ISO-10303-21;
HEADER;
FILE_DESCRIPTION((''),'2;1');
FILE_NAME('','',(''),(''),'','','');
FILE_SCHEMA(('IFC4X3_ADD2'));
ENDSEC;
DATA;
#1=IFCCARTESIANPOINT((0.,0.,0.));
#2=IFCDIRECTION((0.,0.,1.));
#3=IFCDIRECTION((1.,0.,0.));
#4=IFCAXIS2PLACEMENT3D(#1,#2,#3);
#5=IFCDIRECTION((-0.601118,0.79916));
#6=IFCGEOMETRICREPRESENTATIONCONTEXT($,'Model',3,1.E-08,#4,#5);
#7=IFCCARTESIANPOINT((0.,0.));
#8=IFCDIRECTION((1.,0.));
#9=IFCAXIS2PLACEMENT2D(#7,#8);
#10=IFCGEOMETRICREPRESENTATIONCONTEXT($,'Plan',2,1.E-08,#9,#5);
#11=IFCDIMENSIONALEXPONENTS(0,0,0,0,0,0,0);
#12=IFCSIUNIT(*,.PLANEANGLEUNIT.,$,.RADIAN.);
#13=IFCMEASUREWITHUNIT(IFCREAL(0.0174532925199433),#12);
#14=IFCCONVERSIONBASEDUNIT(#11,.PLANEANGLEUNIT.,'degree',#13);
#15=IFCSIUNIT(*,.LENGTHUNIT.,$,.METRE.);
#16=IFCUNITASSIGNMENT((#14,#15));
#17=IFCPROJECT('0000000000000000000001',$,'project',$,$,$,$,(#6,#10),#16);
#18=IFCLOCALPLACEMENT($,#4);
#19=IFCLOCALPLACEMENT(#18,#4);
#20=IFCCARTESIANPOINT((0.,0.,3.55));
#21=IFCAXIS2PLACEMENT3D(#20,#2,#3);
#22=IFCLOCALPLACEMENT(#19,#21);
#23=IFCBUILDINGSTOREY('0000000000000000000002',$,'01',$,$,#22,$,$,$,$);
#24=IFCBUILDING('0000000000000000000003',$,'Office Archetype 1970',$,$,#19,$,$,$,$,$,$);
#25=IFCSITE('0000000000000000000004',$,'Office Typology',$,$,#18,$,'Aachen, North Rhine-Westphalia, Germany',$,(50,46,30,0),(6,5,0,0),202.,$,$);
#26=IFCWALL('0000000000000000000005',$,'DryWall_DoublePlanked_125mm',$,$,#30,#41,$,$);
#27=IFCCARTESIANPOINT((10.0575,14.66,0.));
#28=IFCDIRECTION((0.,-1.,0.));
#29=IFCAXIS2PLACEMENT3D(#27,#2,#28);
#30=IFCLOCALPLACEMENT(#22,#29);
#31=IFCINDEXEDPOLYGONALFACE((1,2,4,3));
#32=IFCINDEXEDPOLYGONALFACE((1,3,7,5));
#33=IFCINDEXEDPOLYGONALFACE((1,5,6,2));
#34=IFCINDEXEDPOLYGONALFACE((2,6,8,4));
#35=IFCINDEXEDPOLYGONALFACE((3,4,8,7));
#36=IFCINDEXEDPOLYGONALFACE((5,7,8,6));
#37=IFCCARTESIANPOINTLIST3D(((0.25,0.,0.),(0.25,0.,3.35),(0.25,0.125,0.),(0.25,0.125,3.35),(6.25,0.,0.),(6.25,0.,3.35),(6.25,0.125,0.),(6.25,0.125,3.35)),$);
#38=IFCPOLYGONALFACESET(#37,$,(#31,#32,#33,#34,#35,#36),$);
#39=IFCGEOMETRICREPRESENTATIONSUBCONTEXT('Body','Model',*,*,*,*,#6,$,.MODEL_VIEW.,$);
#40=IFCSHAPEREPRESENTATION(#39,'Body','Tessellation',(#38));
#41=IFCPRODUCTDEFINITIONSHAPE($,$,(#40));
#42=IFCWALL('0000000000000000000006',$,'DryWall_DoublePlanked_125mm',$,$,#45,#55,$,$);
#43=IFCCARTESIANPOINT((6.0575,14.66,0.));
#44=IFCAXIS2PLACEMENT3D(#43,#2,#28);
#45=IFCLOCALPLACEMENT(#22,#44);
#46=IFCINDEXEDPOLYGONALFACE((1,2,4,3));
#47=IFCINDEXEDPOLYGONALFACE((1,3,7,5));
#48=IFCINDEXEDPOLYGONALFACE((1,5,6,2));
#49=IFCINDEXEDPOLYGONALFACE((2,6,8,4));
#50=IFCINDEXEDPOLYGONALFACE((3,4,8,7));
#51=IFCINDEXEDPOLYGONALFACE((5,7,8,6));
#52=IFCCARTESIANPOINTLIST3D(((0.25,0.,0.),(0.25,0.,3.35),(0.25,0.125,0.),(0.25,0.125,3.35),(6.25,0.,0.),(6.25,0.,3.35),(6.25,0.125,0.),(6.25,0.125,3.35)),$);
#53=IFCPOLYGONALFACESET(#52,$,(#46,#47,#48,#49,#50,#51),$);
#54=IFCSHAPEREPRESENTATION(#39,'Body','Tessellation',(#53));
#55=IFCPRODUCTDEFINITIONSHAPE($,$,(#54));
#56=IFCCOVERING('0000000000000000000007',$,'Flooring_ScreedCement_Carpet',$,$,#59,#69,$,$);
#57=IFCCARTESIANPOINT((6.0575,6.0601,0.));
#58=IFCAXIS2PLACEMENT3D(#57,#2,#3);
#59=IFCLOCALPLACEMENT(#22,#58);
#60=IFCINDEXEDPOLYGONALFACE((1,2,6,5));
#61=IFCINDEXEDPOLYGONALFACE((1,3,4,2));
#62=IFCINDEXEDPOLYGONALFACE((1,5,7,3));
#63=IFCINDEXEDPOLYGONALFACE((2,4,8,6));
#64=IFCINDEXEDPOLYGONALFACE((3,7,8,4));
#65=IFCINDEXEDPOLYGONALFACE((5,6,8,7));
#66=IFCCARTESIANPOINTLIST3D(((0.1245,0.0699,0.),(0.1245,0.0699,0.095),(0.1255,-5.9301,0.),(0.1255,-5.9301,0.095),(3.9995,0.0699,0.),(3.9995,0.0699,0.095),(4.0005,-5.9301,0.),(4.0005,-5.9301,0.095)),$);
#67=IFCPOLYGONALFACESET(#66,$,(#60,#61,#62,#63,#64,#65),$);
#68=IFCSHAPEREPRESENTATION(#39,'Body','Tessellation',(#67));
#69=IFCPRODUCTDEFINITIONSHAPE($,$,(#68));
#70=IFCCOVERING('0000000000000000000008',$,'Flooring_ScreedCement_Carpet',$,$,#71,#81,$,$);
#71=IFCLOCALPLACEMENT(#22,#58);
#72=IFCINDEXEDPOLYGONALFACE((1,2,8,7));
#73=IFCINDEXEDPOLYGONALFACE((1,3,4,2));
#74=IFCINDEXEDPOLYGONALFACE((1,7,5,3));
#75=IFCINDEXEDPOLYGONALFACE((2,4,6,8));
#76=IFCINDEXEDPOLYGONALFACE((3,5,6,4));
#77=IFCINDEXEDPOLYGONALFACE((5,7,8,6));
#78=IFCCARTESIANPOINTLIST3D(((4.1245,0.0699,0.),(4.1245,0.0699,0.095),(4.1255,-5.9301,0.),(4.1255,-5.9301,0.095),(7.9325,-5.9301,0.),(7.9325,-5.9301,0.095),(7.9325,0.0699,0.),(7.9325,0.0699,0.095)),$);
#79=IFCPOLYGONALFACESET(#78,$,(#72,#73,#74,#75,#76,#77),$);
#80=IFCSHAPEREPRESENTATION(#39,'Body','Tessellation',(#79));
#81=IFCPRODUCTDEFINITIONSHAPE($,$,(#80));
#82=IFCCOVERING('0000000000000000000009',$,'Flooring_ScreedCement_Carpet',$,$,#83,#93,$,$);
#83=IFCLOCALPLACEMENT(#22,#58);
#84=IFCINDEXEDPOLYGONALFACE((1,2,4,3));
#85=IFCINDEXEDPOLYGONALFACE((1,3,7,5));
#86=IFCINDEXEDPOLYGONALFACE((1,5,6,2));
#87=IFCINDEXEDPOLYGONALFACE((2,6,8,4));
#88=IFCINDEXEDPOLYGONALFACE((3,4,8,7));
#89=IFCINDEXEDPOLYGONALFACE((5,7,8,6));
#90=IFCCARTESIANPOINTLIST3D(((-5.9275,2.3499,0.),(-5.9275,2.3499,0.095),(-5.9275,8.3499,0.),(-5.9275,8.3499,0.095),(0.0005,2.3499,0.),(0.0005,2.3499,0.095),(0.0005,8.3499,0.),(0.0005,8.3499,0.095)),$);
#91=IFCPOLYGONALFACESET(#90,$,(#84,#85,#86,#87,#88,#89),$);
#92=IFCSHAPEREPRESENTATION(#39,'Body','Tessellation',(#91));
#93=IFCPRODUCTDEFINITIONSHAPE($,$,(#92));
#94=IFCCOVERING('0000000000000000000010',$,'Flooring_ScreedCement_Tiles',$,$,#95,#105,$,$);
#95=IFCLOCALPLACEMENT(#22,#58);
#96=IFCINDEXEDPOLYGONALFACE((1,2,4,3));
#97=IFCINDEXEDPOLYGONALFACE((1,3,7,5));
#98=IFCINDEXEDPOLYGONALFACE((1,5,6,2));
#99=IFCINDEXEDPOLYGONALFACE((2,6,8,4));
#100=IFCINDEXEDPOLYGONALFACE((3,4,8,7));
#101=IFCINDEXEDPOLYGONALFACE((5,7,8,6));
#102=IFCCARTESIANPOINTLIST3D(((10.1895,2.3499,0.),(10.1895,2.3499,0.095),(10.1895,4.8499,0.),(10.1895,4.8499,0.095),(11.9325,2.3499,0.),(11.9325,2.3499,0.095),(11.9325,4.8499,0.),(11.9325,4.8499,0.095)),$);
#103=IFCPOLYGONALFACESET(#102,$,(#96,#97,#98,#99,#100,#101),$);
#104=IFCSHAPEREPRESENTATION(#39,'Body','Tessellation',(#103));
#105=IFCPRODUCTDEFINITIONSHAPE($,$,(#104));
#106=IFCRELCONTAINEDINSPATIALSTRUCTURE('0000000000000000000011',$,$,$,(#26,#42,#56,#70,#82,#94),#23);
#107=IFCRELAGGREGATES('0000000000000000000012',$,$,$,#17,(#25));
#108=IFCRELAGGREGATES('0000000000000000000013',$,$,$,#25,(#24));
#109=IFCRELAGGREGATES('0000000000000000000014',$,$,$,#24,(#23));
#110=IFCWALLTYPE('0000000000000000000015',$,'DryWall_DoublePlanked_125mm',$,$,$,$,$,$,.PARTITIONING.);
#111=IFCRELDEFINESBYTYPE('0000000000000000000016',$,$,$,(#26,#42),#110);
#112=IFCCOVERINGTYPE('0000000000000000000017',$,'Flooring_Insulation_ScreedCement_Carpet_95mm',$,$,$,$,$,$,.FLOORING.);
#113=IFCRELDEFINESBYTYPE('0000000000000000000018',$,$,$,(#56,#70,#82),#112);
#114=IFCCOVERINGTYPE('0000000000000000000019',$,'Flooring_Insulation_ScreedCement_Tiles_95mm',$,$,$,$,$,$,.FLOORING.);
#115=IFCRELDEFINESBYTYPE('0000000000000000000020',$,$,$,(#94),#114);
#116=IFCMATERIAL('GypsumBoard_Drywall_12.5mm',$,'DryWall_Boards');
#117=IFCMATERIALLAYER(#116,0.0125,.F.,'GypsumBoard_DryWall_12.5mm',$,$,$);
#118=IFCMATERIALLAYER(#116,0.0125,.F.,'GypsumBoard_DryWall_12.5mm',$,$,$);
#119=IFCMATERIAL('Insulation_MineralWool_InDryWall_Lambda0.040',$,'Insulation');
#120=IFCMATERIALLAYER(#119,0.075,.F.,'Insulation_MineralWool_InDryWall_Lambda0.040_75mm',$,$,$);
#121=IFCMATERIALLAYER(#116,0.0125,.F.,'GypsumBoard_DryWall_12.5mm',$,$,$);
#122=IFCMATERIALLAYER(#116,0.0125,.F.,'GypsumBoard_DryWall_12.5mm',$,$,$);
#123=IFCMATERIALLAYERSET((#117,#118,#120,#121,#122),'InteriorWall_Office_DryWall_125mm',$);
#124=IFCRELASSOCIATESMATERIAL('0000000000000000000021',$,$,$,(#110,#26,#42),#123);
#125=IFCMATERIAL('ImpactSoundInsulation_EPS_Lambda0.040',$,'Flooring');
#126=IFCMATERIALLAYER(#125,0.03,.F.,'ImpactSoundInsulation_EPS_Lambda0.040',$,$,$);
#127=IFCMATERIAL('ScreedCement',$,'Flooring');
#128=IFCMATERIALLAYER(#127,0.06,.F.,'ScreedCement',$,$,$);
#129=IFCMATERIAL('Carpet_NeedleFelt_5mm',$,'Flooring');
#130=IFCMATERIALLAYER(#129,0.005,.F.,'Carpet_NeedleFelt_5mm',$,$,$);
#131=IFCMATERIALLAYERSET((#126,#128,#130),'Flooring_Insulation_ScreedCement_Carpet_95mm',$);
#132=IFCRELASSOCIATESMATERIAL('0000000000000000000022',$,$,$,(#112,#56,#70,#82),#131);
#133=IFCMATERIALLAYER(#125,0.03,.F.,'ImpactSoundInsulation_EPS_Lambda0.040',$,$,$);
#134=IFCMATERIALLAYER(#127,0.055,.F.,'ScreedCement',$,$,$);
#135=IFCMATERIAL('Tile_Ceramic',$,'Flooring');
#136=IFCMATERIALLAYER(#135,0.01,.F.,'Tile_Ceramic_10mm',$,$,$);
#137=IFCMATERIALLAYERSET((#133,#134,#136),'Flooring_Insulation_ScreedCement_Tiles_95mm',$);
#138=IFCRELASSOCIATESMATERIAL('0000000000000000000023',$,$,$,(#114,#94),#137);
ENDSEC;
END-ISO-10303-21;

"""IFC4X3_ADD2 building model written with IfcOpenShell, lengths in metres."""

from ifc_helpers import new_model, entity, si_unit, converted_unit, direction, frame, origin_with_axes, origin_2d_with_axis, place, context, subcontext, project, spatial, line, indexed_curve, outline, extrude, material, layer, layer_set, layer_usage, type_object, element, save


model = new_model("IFC4X3_ADD2")

# Units and contexts
model_context = context("Model", 3, precision=1e-08, world=origin_with_axes(), true_north=direction((-0.601118, 0.79916)))
plan_context = context("Plan", 2, precision=1e-08, world=origin_2d_with_axis(), true_north=direction((-0.601118, 0.79916)))
body_context = subcontext(model_context, "Body", "Model", "MODEL_VIEW")
ifc_project = project(units=[converted_unit("PLANEANGLEUNIT", "degree", entity("IfcReal", 0.0174532925199433), si_unit("PLANEANGLEUNIT", "RADIAN"), dimensions=[0, 0, 0, 0, 0, 0, 0]), si_unit("LENGTHUNIT", "METRE")], contexts=[model_context, plan_context])

# Site, building, storey
site_placement = place(None, origin_with_axes())
site = spatial("IfcSite", under=ifc_project, at=site_placement, Name="Office Typology", LongName="Aachen, North Rhine-Westphalia, Germany", RefLatitude=(50, 46, 30, 0), RefLongitude=(6, 5, 0, 0), RefElevation=202.0)
building_placement = place(site_placement, origin_with_axes())
building = spatial("IfcBuilding", under=site, at=building_placement, Name="Office Archetype 1970")
storey_placement = place(building_placement, frame((0.0, 0.0, 3.55), z_axis=(0.0, 0.0, 1.0), x_axis=(1.0, 0.0, 0.0)))
storey = spatial("IfcBuildingStorey", under=building, at=storey_placement, Name="01")

# Walls
ifc_material_1 = material(Name="GypsumBoard_Drywall_12.5mm", Category="DryWall_Boards")
ifc_layer_1 = layer(ifc_material_1, 0.0125, ventilated=False, Name="GypsumBoard_DryWall_12.5mm")
ifc_layer_2 = layer(ifc_material_1, 0.0125, ventilated=False, Name="GypsumBoard_DryWall_12.5mm")
ifc_material_2 = material(Name="Insulation_MineralWool_InDryWall_Lambda0.040", Category="Insulation")
ifc_layer_3 = layer(ifc_material_2, 0.075, ventilated=False, Name="Insulation_MineralWool_InDryWall_Lambda0.040_75mm")
ifc_layer_4 = layer(ifc_material_1, 0.0125, ventilated=False, Name="GypsumBoard_DryWall_12.5mm")
ifc_layer_5 = layer(ifc_material_1, 0.0125, ventilated=False, Name="GypsumBoard_DryWall_12.5mm")
ifc_layer_set_1 = layer_set([ifc_layer_1, ifc_layer_2, ifc_layer_3, ifc_layer_4, ifc_layer_5], Name="InteriorWall_Office_DryWall_125mm")
ifc_layer_usage_1 = layer_usage(ifc_layer_set_1, "AXIS2", "POSITIVE", 0.0)
wall_type_1 = type_object("IfcWallType", Name="DryWall_DoublePlanked_125mm", PredefinedType="PARTITIONING", material=ifc_layer_set_1)
wall_1_placement = place(storey_placement, frame((10.0575, 14.66, 0.0), z_axis=(0.0, 0.0, 1.0), x_axis=(0.0, -1.0, 0.0)))
element("IfcWall", 1, at=wall_1_placement, inside=storey, type_object=wall_type_1, material=ifc_layer_usage_1, Name="DryWall_DoublePlanked_125mm", context=body_context, shape_type="SweptSolid", body=[
    extrude(outline(indexed_curve([(0.25, 0.0), (0.25, 0.125), (6.25, 0.125), (6.25, 0.0)], segments=[line(1, 2, 3, 4, 1)])), origin_with_axes(), (0.0, 0.0, 1.0), 3.35),
])
ifc_layer_usage_2 = layer_usage(ifc_layer_set_1, "AXIS2", "POSITIVE", 0.0)
wall_2_placement = place(storey_placement, frame((6.0575, 14.66, 0.0), z_axis=(0.0, 0.0, 1.0), x_axis=(0.0, -1.0, 0.0)))
element("IfcWall", 2, at=wall_2_placement, inside=storey, type_object=wall_type_1, material=ifc_layer_usage_2, Name="DryWall_DoublePlanked_125mm", context=body_context, shape_type="SweptSolid", body=[
    extrude(outline(indexed_curve([(0.25, 0.0), (0.25, 0.125), (6.25, 0.125), (6.25, 0.0)], segments=[line(1, 2, 3, 4, 1)])), origin_with_axes(), (0.0, 0.0, 1.0), 3.35),
])

# Coverings
ifc_material_3 = material(Name="ImpactSoundInsulation_EPS_Lambda0.040", Category="Flooring")
ifc_layer_6 = layer(ifc_material_3, 0.03, ventilated=False, Name="ImpactSoundInsulation_EPS_Lambda0.040")
ifc_material_4 = material(Name="ScreedCement", Category="Flooring")
ifc_layer_7 = layer(ifc_material_4, 0.06, ventilated=False, Name="ScreedCement")
ifc_material_5 = material(Name="Carpet_NeedleFelt_5mm", Category="Flooring")
ifc_layer_8 = layer(ifc_material_5, 0.005, ventilated=False, Name="Carpet_NeedleFelt_5mm")
ifc_layer_set_2 = layer_set([ifc_layer_6, ifc_layer_7, ifc_layer_8], Name="Flooring_Insulation_ScreedCement_Carpet_95mm")
ifc_layer_usage_3 = layer_usage(ifc_layer_set_2, "AXIS3", "POSITIVE", 0.0)
covering_type_1 = type_object("IfcCoveringType", Name="Flooring_Insulation_ScreedCement_Carpet_95mm", PredefinedType="FLOORING", material=ifc_layer_set_2)
covering_1_placement = place(storey_placement, frame((6.0575, 6.0601, 0.0), z_axis=(0.0, 0.0, 1.0), x_axis=(1.0, 0.0, 0.0)))
element("IfcCovering", 3, at=covering_1_placement, inside=storey, type_object=covering_type_1, material=ifc_layer_usage_3, Name="Flooring_ScreedCement_Carpet", context=body_context, shape_type="SweptSolid", body=[
    extrude(outline(indexed_curve([(0.1255, -5.9301), (0.1245, 0.0699), (3.9995, 0.0699), (4.0005, -5.9301)], segments=[line(1, 2, 3, 4, 1)])), origin_with_axes(), (0.0, 0.0, 1.0), 0.095),
])
ifc_layer_usage_4 = layer_usage(ifc_layer_set_2, "AXIS3", "POSITIVE", 0.0)
covering_2_placement = place(storey_placement, frame((6.0575, 6.0601, 0.0), z_axis=(0.0, 0.0, 1.0), x_axis=(1.0, 0.0, 0.0)))
element("IfcCovering", 4, at=covering_2_placement, inside=storey, type_object=covering_type_1, material=ifc_layer_usage_4, Name="Flooring_ScreedCement_Carpet", context=body_context, shape_type="SweptSolid", body=[
    extrude(outline(indexed_curve([(4.1245, 0.0699), (7.9325, 0.0699), (7.9325, -5.9301), (4.1255, -5.9301)], segments=[line(1, 2, 3, 4, 1)])), origin_with_axes(), (0.0, 0.0, 1.0), 0.095),
])
ifc_layer_usage_5 = layer_usage(ifc_layer_set_2, "AXIS3", "POSITIVE", 0.0)
covering_3_placement = place(storey_placement, frame((6.0575, 6.0601, 0.0), z_axis=(0.0, 0.0, 1.0), x_axis=(1.0, 0.0, 0.0)))
element("IfcCovering", 5, at=covering_3_placement, inside=storey, type_object=covering_type_1, material=ifc_layer_usage_5, Name="Flooring_ScreedCement_Carpet", context=body_context, shape_type="SweptSolid", body=[
    extrude(outline(indexed_curve([(-5.9275, 2.3499), (-5.9275, 8.3499), (0.0005, 8.3499), (0.0005, 2.3499)], segments=[line(1, 2, 3, 4, 1)])), origin_with_axes(), (0.0, 0.0, 1.0), 0.095),
])
ifc_layer_9 = layer(ifc_material_3, 0.03, ventilated=False, Name="ImpactSoundInsulation_EPS_Lambda0.040")
ifc_layer_10 = layer(ifc_material_4, 0.055, ventilated=False, Name="ScreedCement")
ifc_material_6 = material(Name="Tile_Ceramic", Category="Flooring")
ifc_layer_11 = layer(ifc_material_6, 0.01, ventilated=False, Name="Tile_Ceramic_10mm")
ifc_layer_set_3 = layer_set([ifc_layer_9, ifc_layer_10, ifc_layer_11], Name="Flooring_Insulation_ScreedCement_Tiles_95mm")
ifc_layer_usage_6 = layer_usage(ifc_layer_set_3, "AXIS3", "POSITIVE", 0.0)
covering_type_2 = type_object("IfcCoveringType", Name="Flooring_Insulation_ScreedCement_Tiles_95mm", PredefinedType="FLOORING", material=ifc_layer_set_3)
covering_4_placement = place(storey_placement, frame((6.0575, 6.0601, 0.0), z_axis=(0.0, 0.0, 1.0), x_axis=(1.0, 0.0, 0.0)))
element("IfcCovering", 6, at=covering_4_placement, inside=storey, type_object=covering_type_2, material=ifc_layer_usage_6, Name="Flooring_ScreedCement_Tiles", context=body_context, shape_type="SweptSolid", body=[
    extrude(outline(indexed_curve([(11.9325, 4.8499), (11.9325, 2.3499), (10.1895, 2.3499), (10.1895, 4.8499)], segments=[line(1, 2, 3, 4, 1)])), None, (0.0, 0.0, 1.0), 0.095),
])

save(model, "model.ifc")
